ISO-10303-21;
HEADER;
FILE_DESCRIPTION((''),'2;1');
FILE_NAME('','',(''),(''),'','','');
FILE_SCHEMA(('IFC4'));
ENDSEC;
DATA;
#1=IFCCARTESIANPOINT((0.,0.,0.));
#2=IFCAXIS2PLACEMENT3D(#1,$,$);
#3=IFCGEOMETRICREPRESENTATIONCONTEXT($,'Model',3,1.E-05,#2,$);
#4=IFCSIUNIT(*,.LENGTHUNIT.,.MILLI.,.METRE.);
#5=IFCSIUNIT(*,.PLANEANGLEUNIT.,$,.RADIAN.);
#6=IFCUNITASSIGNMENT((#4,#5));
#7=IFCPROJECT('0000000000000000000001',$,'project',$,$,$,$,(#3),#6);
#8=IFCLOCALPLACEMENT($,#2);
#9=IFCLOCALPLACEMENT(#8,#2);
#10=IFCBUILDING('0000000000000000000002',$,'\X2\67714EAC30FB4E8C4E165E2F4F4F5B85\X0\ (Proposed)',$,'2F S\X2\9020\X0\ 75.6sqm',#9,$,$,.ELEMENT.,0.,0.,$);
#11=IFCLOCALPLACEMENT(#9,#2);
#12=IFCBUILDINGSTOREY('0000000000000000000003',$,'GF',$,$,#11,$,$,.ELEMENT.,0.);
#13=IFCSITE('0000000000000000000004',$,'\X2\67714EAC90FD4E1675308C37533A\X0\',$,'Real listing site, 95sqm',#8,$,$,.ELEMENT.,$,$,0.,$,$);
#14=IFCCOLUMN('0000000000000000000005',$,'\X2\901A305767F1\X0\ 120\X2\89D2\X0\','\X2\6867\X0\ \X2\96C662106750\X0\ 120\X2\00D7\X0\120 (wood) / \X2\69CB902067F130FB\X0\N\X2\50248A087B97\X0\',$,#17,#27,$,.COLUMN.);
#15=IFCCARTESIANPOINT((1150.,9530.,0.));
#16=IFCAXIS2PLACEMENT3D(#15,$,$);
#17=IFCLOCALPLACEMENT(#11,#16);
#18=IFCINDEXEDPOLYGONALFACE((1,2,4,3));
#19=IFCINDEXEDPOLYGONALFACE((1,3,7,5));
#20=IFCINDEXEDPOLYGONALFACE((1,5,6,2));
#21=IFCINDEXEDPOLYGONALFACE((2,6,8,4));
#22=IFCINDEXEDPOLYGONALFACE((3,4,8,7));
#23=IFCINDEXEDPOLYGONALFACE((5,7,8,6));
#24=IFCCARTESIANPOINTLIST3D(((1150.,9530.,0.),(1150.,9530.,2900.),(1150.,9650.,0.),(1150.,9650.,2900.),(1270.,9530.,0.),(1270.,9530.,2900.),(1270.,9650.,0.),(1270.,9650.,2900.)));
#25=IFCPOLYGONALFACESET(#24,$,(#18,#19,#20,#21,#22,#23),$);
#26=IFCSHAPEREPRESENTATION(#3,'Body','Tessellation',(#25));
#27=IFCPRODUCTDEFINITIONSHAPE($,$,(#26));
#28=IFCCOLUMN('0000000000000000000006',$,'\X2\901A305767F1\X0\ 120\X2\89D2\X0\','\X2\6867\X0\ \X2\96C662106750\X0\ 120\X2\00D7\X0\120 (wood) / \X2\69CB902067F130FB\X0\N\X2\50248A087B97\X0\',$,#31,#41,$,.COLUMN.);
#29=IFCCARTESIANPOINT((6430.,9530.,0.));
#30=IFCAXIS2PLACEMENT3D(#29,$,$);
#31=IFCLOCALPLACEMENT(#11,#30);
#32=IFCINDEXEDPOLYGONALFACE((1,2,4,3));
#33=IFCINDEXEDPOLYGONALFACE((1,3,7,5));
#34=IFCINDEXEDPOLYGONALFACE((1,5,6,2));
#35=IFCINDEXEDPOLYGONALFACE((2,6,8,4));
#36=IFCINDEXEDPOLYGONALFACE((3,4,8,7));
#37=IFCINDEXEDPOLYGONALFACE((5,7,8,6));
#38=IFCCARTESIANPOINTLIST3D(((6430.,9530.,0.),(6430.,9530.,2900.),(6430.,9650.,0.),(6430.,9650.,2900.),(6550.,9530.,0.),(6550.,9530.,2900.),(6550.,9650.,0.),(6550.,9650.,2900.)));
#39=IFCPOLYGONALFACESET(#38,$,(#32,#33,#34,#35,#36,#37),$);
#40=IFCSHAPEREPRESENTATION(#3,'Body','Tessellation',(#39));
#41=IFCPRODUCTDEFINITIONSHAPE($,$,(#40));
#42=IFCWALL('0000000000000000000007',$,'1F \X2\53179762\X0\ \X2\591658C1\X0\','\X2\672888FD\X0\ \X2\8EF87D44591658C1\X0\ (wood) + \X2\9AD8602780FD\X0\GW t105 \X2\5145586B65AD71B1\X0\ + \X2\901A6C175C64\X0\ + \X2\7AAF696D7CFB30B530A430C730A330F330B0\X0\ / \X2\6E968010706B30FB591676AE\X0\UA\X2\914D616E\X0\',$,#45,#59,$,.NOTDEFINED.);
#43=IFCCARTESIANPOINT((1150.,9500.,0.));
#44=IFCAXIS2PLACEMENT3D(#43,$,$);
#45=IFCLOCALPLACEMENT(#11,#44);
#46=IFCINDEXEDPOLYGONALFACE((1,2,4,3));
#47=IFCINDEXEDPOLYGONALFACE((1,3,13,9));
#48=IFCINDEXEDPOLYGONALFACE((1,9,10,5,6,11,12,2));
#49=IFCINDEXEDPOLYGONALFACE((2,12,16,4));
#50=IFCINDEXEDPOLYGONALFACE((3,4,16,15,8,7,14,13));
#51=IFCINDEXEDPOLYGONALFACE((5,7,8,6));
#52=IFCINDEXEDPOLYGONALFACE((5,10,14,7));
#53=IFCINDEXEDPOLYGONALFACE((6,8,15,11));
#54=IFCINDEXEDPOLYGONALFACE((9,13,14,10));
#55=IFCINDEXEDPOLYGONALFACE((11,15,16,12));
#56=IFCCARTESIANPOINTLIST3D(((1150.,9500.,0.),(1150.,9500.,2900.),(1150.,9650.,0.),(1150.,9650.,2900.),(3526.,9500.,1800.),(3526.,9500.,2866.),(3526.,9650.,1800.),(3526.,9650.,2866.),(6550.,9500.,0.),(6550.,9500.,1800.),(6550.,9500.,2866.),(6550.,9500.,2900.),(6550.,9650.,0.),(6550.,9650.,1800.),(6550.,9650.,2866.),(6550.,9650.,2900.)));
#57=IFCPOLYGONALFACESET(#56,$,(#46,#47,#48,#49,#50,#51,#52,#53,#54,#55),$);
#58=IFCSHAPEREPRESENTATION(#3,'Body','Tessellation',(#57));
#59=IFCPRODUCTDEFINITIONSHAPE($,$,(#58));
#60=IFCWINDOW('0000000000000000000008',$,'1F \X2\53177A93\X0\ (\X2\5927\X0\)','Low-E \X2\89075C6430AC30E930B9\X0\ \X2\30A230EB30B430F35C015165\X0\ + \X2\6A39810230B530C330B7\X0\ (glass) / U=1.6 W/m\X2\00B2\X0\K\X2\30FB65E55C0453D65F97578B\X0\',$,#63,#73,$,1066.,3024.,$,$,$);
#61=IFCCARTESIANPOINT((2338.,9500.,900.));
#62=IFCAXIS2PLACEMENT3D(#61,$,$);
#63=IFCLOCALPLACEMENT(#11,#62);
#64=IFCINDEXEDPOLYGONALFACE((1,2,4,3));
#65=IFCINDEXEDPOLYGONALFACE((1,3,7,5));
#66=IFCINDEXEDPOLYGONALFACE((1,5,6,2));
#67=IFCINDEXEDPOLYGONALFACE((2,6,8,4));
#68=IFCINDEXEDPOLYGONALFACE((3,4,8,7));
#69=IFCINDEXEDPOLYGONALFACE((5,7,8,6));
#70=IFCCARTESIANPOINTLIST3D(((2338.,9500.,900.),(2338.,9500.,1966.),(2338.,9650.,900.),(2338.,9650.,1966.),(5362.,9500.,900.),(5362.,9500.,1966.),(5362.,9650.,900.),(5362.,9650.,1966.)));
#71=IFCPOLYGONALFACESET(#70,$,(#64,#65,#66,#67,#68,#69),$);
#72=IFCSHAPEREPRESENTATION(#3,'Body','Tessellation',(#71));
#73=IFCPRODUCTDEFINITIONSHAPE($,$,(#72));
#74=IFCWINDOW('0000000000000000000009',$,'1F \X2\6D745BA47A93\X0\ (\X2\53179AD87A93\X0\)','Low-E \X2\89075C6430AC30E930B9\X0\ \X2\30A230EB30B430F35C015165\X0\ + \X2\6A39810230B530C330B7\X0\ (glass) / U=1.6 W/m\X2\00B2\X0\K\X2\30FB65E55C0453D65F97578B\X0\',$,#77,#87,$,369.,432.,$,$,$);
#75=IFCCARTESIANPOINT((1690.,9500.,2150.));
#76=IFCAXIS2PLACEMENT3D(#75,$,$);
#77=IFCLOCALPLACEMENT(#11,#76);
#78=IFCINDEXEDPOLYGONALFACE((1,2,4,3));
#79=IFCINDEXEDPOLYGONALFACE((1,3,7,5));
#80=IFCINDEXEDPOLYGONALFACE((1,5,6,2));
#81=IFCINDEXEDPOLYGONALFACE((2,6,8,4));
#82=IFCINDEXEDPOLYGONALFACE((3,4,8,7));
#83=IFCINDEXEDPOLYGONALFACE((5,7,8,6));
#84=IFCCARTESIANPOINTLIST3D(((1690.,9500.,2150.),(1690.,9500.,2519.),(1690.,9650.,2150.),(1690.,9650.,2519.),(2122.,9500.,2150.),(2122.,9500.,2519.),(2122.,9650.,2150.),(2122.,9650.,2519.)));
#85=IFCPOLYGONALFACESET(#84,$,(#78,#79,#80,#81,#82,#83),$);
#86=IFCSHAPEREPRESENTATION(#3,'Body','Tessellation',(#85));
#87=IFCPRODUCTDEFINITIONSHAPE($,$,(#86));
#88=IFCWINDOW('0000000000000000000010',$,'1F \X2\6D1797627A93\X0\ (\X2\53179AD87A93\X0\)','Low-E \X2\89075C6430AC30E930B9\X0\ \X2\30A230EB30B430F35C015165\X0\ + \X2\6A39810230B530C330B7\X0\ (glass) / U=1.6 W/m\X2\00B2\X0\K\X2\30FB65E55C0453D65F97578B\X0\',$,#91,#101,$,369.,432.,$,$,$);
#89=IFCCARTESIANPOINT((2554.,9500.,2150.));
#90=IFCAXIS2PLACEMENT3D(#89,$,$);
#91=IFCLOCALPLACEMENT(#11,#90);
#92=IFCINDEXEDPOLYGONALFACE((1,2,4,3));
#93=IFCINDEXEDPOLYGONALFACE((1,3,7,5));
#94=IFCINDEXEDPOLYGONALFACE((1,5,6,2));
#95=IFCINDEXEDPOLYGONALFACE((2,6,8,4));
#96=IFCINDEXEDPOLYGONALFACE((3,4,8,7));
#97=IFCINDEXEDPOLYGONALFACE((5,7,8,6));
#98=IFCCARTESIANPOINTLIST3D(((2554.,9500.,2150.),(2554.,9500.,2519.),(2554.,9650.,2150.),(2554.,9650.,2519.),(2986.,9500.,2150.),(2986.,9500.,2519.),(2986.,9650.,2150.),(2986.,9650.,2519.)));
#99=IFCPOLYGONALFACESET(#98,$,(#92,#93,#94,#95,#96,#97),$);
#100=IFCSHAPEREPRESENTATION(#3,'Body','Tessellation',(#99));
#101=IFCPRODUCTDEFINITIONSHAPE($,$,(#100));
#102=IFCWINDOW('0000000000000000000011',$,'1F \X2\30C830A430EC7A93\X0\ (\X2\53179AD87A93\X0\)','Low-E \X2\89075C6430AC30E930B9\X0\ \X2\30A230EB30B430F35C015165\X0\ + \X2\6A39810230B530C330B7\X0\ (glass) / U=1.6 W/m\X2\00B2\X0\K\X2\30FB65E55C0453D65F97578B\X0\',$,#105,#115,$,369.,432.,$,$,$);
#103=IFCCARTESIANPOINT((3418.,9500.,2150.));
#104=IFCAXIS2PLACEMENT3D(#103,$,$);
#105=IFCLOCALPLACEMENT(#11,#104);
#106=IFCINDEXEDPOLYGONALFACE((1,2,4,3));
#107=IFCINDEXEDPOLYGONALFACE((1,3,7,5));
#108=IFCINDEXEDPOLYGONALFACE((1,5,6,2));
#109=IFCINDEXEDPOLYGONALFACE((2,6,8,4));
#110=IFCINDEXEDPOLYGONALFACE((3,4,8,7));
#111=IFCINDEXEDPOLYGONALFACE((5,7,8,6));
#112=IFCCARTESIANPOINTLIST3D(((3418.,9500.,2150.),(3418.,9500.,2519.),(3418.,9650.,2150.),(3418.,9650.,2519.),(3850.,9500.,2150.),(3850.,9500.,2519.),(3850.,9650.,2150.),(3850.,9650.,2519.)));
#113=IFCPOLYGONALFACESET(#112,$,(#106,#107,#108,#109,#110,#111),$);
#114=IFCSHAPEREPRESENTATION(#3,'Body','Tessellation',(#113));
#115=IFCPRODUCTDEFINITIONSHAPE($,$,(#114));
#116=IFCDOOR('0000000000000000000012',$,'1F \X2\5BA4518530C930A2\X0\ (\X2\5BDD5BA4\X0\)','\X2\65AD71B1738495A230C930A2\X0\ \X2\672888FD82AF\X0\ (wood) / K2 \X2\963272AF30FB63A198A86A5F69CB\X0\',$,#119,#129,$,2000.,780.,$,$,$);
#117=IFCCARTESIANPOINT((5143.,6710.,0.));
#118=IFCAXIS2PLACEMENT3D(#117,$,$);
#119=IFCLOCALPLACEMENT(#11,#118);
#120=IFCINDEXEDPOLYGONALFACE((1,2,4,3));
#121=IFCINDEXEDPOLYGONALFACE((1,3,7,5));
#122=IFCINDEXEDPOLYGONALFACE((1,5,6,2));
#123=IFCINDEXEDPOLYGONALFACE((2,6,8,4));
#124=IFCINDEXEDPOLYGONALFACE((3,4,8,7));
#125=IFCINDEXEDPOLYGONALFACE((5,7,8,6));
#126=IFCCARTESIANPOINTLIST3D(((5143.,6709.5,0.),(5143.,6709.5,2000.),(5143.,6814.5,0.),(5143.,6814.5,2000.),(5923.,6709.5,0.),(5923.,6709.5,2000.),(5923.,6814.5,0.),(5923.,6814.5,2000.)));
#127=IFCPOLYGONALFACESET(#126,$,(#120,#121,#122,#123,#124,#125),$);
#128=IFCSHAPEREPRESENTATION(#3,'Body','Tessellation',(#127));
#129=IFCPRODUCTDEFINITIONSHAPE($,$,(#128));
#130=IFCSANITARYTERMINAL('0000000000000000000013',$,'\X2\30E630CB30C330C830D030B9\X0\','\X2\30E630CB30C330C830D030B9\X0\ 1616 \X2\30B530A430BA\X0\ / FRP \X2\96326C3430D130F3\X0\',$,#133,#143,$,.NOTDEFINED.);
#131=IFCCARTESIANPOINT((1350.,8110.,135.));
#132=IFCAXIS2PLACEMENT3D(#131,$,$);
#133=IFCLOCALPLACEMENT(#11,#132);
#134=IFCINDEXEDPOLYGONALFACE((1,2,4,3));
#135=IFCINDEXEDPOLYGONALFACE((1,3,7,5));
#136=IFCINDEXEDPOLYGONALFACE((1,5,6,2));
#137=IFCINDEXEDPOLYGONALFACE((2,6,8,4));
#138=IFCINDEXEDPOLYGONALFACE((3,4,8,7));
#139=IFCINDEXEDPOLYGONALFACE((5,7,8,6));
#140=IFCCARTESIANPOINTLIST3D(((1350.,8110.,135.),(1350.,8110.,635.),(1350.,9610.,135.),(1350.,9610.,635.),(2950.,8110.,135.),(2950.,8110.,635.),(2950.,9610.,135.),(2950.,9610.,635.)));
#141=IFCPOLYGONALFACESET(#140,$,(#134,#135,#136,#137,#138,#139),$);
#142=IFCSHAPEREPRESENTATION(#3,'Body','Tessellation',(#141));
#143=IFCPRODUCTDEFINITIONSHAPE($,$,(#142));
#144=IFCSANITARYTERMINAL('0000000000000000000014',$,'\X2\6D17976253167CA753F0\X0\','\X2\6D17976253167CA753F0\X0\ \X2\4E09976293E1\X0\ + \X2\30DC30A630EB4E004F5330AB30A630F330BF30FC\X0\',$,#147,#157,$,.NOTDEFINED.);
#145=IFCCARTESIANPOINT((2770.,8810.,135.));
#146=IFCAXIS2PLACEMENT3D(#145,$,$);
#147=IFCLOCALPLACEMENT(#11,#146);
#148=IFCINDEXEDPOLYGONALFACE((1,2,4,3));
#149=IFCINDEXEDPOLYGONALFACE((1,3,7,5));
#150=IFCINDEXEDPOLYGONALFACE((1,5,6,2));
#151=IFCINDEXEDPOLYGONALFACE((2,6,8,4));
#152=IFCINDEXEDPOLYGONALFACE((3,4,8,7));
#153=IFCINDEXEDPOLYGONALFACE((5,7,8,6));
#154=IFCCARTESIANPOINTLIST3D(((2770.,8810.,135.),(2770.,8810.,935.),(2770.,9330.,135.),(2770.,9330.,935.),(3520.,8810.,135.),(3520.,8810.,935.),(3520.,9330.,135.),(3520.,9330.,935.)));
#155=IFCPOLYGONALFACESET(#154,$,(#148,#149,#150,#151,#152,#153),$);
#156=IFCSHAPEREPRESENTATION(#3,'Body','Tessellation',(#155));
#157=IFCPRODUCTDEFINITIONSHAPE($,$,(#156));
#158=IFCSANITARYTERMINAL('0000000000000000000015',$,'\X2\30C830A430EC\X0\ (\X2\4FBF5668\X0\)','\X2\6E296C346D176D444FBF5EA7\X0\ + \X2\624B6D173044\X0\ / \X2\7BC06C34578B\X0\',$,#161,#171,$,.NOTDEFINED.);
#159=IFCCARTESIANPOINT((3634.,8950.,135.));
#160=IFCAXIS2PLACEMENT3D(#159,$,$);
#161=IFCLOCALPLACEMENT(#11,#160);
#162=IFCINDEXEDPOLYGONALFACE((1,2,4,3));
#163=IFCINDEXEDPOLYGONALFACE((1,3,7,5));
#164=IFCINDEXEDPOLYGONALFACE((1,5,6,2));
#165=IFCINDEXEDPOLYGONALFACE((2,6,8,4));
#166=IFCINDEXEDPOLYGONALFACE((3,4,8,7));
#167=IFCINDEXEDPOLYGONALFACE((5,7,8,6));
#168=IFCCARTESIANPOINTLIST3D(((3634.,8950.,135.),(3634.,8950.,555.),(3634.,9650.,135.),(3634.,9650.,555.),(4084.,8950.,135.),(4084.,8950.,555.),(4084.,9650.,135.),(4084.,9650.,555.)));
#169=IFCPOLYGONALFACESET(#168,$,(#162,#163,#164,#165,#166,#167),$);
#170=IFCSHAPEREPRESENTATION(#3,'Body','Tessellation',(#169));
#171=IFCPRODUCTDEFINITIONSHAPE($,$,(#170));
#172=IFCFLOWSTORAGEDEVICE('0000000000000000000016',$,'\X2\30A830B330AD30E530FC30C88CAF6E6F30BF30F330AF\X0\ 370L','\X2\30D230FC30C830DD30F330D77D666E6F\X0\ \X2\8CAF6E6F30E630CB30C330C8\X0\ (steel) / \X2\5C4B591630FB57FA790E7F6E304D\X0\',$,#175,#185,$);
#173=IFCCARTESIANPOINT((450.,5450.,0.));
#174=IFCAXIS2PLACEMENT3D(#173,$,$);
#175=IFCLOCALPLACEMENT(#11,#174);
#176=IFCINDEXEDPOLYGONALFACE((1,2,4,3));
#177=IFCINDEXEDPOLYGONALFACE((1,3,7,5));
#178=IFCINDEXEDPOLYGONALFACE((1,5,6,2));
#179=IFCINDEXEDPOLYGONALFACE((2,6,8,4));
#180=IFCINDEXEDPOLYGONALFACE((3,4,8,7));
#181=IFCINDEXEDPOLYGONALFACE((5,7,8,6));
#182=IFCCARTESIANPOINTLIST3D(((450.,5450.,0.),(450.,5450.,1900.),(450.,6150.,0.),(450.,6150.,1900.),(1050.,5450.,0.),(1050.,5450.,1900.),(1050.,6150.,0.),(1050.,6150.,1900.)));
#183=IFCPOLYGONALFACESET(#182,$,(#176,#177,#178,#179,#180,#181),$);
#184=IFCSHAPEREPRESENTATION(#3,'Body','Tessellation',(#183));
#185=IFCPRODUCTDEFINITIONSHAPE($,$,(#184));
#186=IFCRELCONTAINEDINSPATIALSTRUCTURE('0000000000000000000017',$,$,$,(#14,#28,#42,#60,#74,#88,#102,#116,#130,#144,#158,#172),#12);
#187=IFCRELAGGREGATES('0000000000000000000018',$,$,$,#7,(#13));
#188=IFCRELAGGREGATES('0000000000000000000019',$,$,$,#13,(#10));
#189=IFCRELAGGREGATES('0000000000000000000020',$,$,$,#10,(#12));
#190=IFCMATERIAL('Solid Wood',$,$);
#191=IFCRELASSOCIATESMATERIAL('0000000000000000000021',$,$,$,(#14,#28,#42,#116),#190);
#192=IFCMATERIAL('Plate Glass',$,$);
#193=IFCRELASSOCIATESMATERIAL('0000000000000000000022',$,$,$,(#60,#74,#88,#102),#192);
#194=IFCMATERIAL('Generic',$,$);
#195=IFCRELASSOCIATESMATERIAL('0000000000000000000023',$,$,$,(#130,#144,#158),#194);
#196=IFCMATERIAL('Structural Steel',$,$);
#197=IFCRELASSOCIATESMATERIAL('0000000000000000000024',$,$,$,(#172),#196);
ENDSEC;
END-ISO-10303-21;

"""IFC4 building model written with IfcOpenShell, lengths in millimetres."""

from ifc_helpers import new_model, si_unit, frame, frame_2d, origin, place, context, project, spatial, rectangle, extrude, material, element, fill, save


model = new_model("IFC4")

# Units and contexts
model_context = context("Model", 3, precision=1e-05, world=origin())
ifc_project = project(units=[si_unit("LENGTHUNIT", "METRE", prefix="MILLI"), si_unit("PLANEANGLEUNIT", "RADIAN")], contexts=[model_context])

# Site, building, storey
site_placement = place(None, origin())
site = spatial("IfcSite", under=ifc_project, at=site_placement, Name="東京都世田谷区", ObjectType="Real listing site, 95sqm", CompositionType="ELEMENT", RefElevation=0.0)
building_placement = place(site_placement, origin())
building = spatial("IfcBuilding", under=site, at=building_placement, Name="東京・二世帯住宅 (Proposed)", ObjectType="2F S造 75.6sqm", CompositionType="ELEMENT", ElevationOfRefHeight=0.0, ElevationOfTerrain=0.0)
storey_placement = place(building_placement, origin())
storey = spatial("IfcBuildingStorey", under=building, at=storey_placement, Name="GF", CompositionType="ELEMENT", Elevation=0.0)

# Columns
ifc_material_1 = material(Name="Solid Wood")
column_1_placement = place(storey_placement, frame((1150.0, 9530.0, 0.0)))
element("IfcColumn", 1, at=column_1_placement, inside=storey, material=ifc_material_1, Name="通し柱 120角", Description="桧 集成材 120×120 (wood) / 構造柱・N値計算", PredefinedType="COLUMN", context=model_context, shape_type="SweptSolid", body=[
    extrude(rectangle(XDim=120.0, YDim=120.0, at=frame_2d((60.0, 60.0))), frame((1150.0, 9530.0, 0.0)), (0.0, 0.0, 1.0), 2900.0),
])
column_2_placement = place(storey_placement, frame((6430.0, 9530.0, 0.0)))
element("IfcColumn", 2, at=column_2_placement, inside=storey, material=ifc_material_1, Name="通し柱 120角", Description="桧 集成材 120×120 (wood) / 構造柱・N値計算", PredefinedType="COLUMN", context=model_context, shape_type="SweptSolid", body=[
    extrude(rectangle(XDim=120.0, YDim=120.0, at=frame_2d((60.0, 60.0))), frame((6430.0, 9530.0, 0.0)), (0.0, 0.0, 1.0), 2900.0),
])

# Wall, openings, windows
wall_1_placement = place(storey_placement, frame((1150.0, 9500.0, 0.0)))
wall_1 = element("IfcWall", 3, at=wall_1_placement, inside=storey, material=ifc_material_1, Name="1F 北面 外壁", Description="木製 軸組外壁 (wood) + 高性能GW t105 充填断熱 + 通気層 + 窯業系サイディング / 準耐火・外皮UA配慮", PredefinedType="NOTDEFINED", context=model_context, shape_type="SweptSolid", body=[
    extrude(rectangle(XDim=5400.0, YDim=150.0, at=frame_2d((2700.0, 75.0))), frame((1150.0, 9500.0, 0.0)), (0.0, 0.0, 1.0), 2900.0),
])
opening_1_placement = place(storey_placement, frame((2338.0, 9500.0, 900.0)))
opening_1 = element("IfcOpeningElement", 4, at=opening_1_placement, cuts=wall_1, PredefinedType="NOTDEFINED", context=model_context, shape_type="SweptSolid", body=[
    extrude(rectangle(XDim=3024.0, YDim=150.0, at=frame_2d((1512.0, 75.0))), frame((2338.0, 9500.0, 900.0)), (0.0, 0.0, 1.0), 1066.0),
])
opening_2_placement = place(storey_placement, frame((1690.0, 9500.0, 2150.0)))
opening_2 = element("IfcOpeningElement", 5, at=opening_2_placement, cuts=wall_1, PredefinedType="NOTDEFINED", context=model_context, shape_type="SweptSolid", body=[
    extrude(rectangle(XDim=432.0, YDim=150.0, at=frame_2d((216.0, 75.0))), frame((1690.0, 9500.0, 2150.0)), (0.0, 0.0, 1.0), 369.0),
])
opening_3_placement = place(storey_placement, frame((2554.0, 9500.0, 2150.0)))
opening_3 = element("IfcOpeningElement", 6, at=opening_3_placement, cuts=wall_1, PredefinedType="NOTDEFINED", context=model_context, shape_type="SweptSolid", body=[
    extrude(rectangle(XDim=432.0, YDim=150.0, at=frame_2d((216.0, 75.0))), frame((2554.0, 9500.0, 2150.0)), (0.0, 0.0, 1.0), 369.0),
])
opening_4_placement = place(storey_placement, frame((3418.0, 9500.0, 2150.0)))
opening_4 = element("IfcOpeningElement", 7, at=opening_4_placement, cuts=wall_1, PredefinedType="NOTDEFINED", context=model_context, shape_type="SweptSolid", body=[
    extrude(rectangle(XDim=432.0, YDim=150.0, at=frame_2d((216.0, 75.0))), frame((3418.0, 9500.0, 2150.0)), (0.0, 0.0, 1.0), 369.0),
])
ifc_material_2 = material(Name="Plate Glass")
window_1_placement = place(storey_placement, frame((2338.0, 9500.0, 900.0)))
window_1 = element("IfcWindow", 8, at=window_1_placement, inside=storey, material=ifc_material_2, Name="1F 北窓 (大)", Description="Low-E 複層ガラス アルゴン封入 + 樹脂サッシ (glass) / U=1.6 W/m²K・日射取得型", OverallHeight=1066.0, OverallWidth=3024.0, context=model_context, shape_type="SweptSolid", body=[
    extrude(rectangle(XDim=3024.0, YDim=150.0, at=frame_2d((1512.0, 75.0))), frame((2338.0, 9500.0, 900.0)), (0.0, 0.0, 1.0), 1066.0),
])
fill(opening_1, window_1)
window_2_placement = place(storey_placement, frame((1690.0, 9500.0, 2150.0)))
window_2 = element("IfcWindow", 9, at=window_2_placement, inside=storey, material=ifc_material_2, Name="1F 浴室窓 (北高窓)", Description="Low-E 複層ガラス アルゴン封入 + 樹脂サッシ (glass) / U=1.6 W/m²K・日射取得型", OverallHeight=369.0, OverallWidth=432.0, context=model_context, shape_type="SweptSolid", body=[
    extrude(rectangle(XDim=432.0, YDim=150.0, at=frame_2d((216.0, 75.0))), frame((1690.0, 9500.0, 2150.0)), (0.0, 0.0, 1.0), 369.0),
])
fill(opening_2, window_2)
window_3_placement = place(storey_placement, frame((2554.0, 9500.0, 2150.0)))
window_3 = element("IfcWindow", 10, at=window_3_placement, inside=storey, material=ifc_material_2, Name="1F 洗面窓 (北高窓)", Description="Low-E 複層ガラス アルゴン封入 + 樹脂サッシ (glass) / U=1.6 W/m²K・日射取得型", OverallHeight=369.0, OverallWidth=432.0, context=model_context, shape_type="SweptSolid", body=[
    extrude(rectangle(XDim=432.0, YDim=150.0, at=frame_2d((216.0, 75.0))), frame((2554.0, 9500.0, 2150.0)), (0.0, 0.0, 1.0), 369.0),
])
fill(opening_3, window_3)
window_4_placement = place(storey_placement, frame((3418.0, 9500.0, 2150.0)))
window_4 = element("IfcWindow", 11, at=window_4_placement, inside=storey, material=ifc_material_2, Name="1F トイレ窓 (北高窓)", Description="Low-E 複層ガラス アルゴン封入 + 樹脂サッシ (glass) / U=1.6 W/m²K・日射取得型", OverallHeight=369.0, OverallWidth=432.0, context=model_context, shape_type="SweptSolid", body=[
    extrude(rectangle(XDim=432.0, YDim=150.0, at=frame_2d((216.0, 75.0))), frame((3418.0, 9500.0, 2150.0)), (0.0, 0.0, 1.0), 369.0),
])
fill(opening_4, window_4)

# Door
door_1_placement = place(storey_placement, frame((5143.0, 6710.0, 0.0)))
element("IfcDoor", 12, at=door_1_placement, inside=storey, material=ifc_material_1, Name="1F 室内ドア (寝室)", Description="断熱玄関ドア 木製芯 (wood) / K2 防犯・採風機構", OverallHeight=2000.0, OverallWidth=780.0, context=model_context, shape_type="SweptSolid", body=[
    extrude(rectangle(XDim=780.0, YDim=105.0, at=frame_2d((390.0, 52.0))), frame((5143.0, 6710.0, 0.0)), (0.0, 0.0, 1.0), 2000.0),
])

# Sanitary terminals
ifc_material_3 = material(Name="Generic")
sanitary_terminal_1_placement = place(storey_placement, frame((1350.0, 8110.0, 135.0)))
element("IfcSanitaryTerminal", 13, at=sanitary_terminal_1_placement, inside=storey, material=ifc_material_3, Name="ユニットバス", Description="ユニットバス 1616 サイズ / FRP 防水パン", PredefinedType="NOTDEFINED", context=model_context, shape_type="SweptSolid", body=[
    extrude(rectangle(XDim=1600.0, YDim=1500.0, at=frame_2d((800.0, 750.0))), frame((1350.0, 8110.0, 135.0)), (0.0, 0.0, 1.0), 500.0),
])
sanitary_terminal_2_placement = place(storey_placement, frame((2770.0, 8810.0, 135.0)))
element("IfcSanitaryTerminal", 14, at=sanitary_terminal_2_placement, inside=storey, material=ifc_material_3, Name="洗面化粧台", Description="洗面化粧台 三面鏡 + ボウル一体カウンター", PredefinedType="NOTDEFINED", context=model_context, shape_type="SweptSolid", body=[
    extrude(rectangle(XDim=750.0, YDim=520.0, at=frame_2d((375.0, 260.0))), frame((2770.0, 8810.0, 135.0)), (0.0, 0.0, 1.0), 800.0),
])
sanitary_terminal_3_placement = place(storey_placement, frame((3634.0, 8950.0, 135.0)))
element("IfcSanitaryTerminal", 15, at=sanitary_terminal_3_placement, inside=storey, material=ifc_material_3, Name="トイレ (便器)", Description="温水洗浄便座 + 手洗い / 節水型", PredefinedType="NOTDEFINED", context=model_context, shape_type="SweptSolid", body=[
    extrude(rectangle(XDim=450.0, YDim=700.0, at=frame_2d((225.0, 350.0))), frame((3634.0, 8950.0, 135.0)), (0.0, 0.0, 1.0), 420.0),
])

# Flow storage device
ifc_material_4 = material(Name="Structural Steel")
flow_storage_device_placement = place(storey_placement, frame((450.0, 5450.0, 0.0)))
element("IfcFlowStorageDevice", 16, at=flow_storage_device_placement, inside=storey, material=ifc_material_4, Name="エコキュート貯湯タンク 370L", Description="ヒートポンプ給湯 貯湯ユニット (steel) / 屋外・基礎置き", context=model_context, shape_type="SweptSolid", body=[
    extrude(rectangle(XDim=600.0, YDim=700.0, at=frame_2d((300.0, 350.0))), frame((450.0, 5450.0, 0.0)), (0.0, 0.0, 1.0), 1900.0),
])

save(model, "model.ifc")
